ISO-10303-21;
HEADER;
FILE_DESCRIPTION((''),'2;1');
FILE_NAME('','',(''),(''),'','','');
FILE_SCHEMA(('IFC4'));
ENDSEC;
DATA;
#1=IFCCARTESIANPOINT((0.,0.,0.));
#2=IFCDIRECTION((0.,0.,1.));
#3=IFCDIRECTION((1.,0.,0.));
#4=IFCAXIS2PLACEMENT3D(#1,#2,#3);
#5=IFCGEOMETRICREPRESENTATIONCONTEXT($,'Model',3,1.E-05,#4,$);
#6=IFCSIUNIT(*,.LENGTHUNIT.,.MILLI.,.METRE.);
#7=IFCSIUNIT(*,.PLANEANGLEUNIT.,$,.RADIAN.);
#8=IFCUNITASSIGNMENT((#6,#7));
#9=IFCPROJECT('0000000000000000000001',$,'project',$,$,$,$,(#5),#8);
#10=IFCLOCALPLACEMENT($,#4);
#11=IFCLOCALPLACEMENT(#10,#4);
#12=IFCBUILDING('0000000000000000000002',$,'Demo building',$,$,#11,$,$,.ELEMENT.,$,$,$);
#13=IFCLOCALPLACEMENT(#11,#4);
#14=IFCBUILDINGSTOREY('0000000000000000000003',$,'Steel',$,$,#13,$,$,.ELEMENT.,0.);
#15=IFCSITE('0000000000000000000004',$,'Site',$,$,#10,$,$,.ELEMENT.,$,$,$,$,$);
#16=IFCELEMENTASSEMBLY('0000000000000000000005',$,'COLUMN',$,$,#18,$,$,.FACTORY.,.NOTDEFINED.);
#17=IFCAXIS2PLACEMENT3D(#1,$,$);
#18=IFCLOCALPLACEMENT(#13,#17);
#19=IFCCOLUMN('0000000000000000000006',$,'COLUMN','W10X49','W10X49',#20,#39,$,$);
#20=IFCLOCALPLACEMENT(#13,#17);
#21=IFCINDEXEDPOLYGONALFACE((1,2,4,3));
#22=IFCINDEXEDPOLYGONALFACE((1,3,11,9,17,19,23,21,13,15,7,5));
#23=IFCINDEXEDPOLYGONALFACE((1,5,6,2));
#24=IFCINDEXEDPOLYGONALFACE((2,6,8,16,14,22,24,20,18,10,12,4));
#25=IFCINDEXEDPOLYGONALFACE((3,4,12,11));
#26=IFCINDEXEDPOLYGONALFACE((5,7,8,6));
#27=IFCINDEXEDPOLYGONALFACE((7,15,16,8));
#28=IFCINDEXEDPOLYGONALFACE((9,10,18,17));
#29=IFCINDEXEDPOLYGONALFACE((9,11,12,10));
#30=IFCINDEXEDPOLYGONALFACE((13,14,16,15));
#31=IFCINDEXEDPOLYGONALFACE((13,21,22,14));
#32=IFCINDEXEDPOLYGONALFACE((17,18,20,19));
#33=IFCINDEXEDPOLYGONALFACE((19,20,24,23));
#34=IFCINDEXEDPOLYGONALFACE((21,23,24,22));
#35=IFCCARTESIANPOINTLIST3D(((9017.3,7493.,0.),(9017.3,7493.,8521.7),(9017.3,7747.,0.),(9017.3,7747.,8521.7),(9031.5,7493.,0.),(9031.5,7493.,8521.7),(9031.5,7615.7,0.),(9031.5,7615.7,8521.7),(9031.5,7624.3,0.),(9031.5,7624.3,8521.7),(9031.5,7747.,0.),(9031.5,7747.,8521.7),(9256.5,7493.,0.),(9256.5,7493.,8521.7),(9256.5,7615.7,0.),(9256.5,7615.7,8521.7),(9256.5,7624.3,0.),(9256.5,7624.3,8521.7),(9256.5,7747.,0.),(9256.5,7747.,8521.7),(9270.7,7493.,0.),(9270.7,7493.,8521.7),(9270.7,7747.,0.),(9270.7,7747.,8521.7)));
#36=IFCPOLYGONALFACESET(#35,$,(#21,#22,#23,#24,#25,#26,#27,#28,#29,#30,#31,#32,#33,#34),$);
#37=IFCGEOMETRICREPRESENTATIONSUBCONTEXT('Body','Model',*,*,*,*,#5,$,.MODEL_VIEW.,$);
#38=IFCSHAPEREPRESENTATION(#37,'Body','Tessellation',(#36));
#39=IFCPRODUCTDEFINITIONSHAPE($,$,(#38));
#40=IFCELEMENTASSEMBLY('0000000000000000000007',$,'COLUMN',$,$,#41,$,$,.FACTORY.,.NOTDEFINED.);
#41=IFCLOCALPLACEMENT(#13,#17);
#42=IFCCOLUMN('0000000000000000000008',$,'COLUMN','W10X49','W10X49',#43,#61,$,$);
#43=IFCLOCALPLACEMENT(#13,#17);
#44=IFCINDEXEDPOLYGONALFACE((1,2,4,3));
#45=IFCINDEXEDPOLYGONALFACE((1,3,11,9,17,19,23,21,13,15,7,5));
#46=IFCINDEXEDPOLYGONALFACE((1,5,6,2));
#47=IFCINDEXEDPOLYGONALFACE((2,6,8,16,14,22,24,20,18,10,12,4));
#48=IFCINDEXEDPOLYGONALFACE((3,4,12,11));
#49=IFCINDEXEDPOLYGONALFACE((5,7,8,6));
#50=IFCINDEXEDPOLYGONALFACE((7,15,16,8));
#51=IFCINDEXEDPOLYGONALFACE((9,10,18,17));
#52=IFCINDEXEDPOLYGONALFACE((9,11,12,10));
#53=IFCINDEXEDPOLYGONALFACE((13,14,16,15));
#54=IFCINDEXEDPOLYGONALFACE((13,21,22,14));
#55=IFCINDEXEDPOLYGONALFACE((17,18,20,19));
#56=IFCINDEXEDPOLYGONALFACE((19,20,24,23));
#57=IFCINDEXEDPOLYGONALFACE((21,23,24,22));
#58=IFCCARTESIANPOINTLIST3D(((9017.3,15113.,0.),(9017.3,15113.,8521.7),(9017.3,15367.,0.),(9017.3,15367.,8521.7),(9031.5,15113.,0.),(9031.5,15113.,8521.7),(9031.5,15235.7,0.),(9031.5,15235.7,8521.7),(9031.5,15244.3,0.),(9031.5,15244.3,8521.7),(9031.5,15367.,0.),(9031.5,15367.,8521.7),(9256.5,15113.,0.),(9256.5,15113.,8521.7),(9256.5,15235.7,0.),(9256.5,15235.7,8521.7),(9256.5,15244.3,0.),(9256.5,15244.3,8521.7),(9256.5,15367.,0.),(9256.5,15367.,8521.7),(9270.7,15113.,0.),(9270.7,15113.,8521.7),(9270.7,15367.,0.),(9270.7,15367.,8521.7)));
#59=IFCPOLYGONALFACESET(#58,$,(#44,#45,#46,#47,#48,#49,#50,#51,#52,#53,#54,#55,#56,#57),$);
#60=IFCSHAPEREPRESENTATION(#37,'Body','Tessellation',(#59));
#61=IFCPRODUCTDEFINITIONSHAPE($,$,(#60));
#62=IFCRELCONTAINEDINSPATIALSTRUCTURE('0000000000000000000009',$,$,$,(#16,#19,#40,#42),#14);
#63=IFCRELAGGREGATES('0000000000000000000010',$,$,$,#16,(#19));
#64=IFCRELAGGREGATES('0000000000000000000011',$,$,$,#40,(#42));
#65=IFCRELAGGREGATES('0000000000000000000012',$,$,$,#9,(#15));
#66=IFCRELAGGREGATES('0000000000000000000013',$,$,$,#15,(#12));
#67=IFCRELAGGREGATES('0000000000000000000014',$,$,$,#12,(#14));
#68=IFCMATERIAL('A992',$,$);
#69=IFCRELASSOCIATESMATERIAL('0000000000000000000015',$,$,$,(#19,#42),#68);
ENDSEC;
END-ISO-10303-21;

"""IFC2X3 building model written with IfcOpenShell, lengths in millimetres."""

from ifc_helpers import new_model, si_unit, frame, origin, origin_with_axes, origin_2d, place, context, subcontext, project, spatial, i_section, extrude, material, element, aggregate, save


model = new_model("IFC2X3")

# Units and contexts
model_context = context("Model", 3, precision=1e-05, world=origin_with_axes())
body_context = subcontext(model_context, "Body", "Model", "MODEL_VIEW")
ifc_project = project(units=[si_unit("LENGTHUNIT", "METRE", prefix="MILLI"), si_unit("PLANEANGLEUNIT", "RADIAN")], contexts=[model_context])

# Site, building, storey
site_placement = place(None, origin_with_axes())
site = spatial("IfcSite", under=ifc_project, at=site_placement, Name="Site", CompositionType="ELEMENT")
building_placement = place(site_placement, origin_with_axes())
building = spatial("IfcBuilding", under=site, at=building_placement, Name="Demo building", CompositionType="ELEMENT")
placement = place(building_placement, origin_with_axes())
storey = spatial("IfcBuildingStorey", under=building, at=placement, Name="Steel", CompositionType="ELEMENT", Elevation=0.0)

# Element assemblies, columns
assembly_1 = element("IfcElementAssembly", 1, at=placement, inside=storey, Name="COLUMN", AssemblyPlace="FACTORY", PredefinedType="NOTDEFINED")
ifc_material_1 = material(Name="A992")
column_1_placement = place(placement, frame((9144.0, 7620.0, 0.0), z_axis=(0.0, 0.0, 1.0), x_axis=(0.0, -1.0, 0.0)))
column_1 = element("IfcColumn", 2, at=column_1_placement, inside=storey, material=ifc_material_1, Name="COLUMN", Description="W10X49", ObjectType="W10X49", context=body_context, shape_type="SweptSolid", body=[
    extrude(i_section(OverallWidth=254.0, OverallDepth=253.5, WebThickness=8.6, FlangeThickness=14.2, at=origin_2d()), origin(), (0.0, 0.0, 1.0), 8521.7),
])
aggregate(assembly_1, [column_1])
assembly_2 = element("IfcElementAssembly", 3, at=placement, inside=storey, Name="COLUMN", AssemblyPlace="FACTORY", PredefinedType="NOTDEFINED")
column_2_placement = place(placement, frame((9144.0, 15240.0, 0.0), z_axis=(0.0, 0.0, 1.0), x_axis=(0.0, -1.0, 0.0)))
column_2 = element("IfcColumn", 4, at=column_2_placement, inside=storey, material=ifc_material_1, Name="COLUMN", Description="W10X49", ObjectType="W10X49", context=body_context, shape_type="SweptSolid", body=[
    extrude(i_section(OverallWidth=254.0, OverallDepth=253.5, WebThickness=8.6, FlangeThickness=14.2, at=origin_2d()), origin(), (0.0, 0.0, 1.0), 8521.7),
])

aggregate(assembly_2, [column_2])

save(model, "model.ifc")
